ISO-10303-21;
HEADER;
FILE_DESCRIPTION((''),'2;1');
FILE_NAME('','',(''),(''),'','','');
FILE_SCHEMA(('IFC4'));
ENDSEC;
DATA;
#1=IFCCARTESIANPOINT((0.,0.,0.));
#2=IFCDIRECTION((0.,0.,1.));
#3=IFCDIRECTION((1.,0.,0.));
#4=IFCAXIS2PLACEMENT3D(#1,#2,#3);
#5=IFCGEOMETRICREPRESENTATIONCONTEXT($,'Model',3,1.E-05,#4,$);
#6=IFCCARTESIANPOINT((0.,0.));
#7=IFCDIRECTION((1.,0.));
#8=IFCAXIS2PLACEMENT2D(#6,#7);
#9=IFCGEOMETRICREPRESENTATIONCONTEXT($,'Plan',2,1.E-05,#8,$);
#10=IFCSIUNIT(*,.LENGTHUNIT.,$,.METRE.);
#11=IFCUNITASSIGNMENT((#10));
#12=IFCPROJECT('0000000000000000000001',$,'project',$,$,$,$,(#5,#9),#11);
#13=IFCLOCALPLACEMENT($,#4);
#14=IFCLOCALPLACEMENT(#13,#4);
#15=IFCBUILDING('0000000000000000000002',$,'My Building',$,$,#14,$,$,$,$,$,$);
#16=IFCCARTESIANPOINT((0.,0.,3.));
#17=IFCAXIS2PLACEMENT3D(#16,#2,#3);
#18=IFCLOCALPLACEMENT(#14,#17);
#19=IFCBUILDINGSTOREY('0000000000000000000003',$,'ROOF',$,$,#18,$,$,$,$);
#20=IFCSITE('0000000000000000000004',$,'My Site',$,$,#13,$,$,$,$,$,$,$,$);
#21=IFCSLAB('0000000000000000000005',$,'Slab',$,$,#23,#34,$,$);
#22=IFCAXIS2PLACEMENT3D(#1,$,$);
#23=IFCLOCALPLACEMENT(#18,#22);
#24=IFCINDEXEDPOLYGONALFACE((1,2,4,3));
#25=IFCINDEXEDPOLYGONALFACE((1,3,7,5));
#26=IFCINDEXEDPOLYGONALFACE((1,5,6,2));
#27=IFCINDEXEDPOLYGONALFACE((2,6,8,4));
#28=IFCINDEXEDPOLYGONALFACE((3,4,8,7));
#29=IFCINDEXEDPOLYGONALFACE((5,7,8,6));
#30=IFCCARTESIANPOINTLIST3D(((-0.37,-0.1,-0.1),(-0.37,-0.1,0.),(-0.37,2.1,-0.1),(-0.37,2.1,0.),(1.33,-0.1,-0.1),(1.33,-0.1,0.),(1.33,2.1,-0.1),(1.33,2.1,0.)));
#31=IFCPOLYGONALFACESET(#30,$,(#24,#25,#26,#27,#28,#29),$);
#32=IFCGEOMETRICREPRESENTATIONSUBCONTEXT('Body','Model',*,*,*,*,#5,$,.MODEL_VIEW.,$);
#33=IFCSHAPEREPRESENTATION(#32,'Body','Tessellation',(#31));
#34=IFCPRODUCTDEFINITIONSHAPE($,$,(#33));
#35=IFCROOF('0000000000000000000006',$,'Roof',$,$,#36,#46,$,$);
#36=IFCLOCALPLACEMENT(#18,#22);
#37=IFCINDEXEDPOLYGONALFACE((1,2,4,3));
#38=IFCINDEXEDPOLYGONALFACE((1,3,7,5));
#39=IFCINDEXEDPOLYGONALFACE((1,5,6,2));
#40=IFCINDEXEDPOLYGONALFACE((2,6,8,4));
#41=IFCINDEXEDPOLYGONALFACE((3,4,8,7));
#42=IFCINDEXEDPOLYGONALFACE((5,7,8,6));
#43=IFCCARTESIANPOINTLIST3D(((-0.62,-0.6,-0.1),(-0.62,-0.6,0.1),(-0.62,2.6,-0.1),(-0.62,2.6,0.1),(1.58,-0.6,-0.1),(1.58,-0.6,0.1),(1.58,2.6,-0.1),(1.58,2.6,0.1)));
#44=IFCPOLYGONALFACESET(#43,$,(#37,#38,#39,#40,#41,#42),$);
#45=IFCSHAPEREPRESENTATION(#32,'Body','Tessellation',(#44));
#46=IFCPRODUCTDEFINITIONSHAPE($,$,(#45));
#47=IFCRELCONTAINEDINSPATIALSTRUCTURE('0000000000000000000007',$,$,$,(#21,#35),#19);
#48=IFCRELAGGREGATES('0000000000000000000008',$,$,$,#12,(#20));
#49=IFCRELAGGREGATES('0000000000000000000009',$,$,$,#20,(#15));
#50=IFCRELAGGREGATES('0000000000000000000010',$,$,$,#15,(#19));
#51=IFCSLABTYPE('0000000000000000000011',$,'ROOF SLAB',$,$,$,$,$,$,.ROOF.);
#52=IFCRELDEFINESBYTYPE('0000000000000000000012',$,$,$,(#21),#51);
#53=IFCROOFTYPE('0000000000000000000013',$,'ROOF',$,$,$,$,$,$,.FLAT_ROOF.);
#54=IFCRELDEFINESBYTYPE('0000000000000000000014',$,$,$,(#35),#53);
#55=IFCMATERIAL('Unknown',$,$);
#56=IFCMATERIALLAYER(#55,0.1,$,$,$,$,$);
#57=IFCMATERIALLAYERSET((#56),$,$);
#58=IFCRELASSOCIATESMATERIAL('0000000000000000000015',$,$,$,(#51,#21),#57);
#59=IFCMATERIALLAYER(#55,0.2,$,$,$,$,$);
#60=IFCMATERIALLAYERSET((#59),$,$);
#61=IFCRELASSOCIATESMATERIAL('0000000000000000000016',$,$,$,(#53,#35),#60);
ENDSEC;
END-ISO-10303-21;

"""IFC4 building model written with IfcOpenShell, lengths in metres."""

from ifc_helpers import new_model, si_unit, frame, origin_with_axes, origin_2d_with_axis, place, context, subcontext, project, spatial, indexed_curve, outline, extrude, material, layer, layer_set, layer_usage, type_object, element, save


model = new_model("IFC4")

# Units and contexts
model_context = context("Model", 3, precision=1e-05, world=origin_with_axes())
plan_context = context("Plan", 2, precision=1e-05, world=origin_2d_with_axis())
body_context = subcontext(model_context, "Body", "Model", "MODEL_VIEW")
ifc_project = project(units=[si_unit("LENGTHUNIT", "METRE")], contexts=[model_context, plan_context])

# Site, building, storey
site_placement = place(None, origin_with_axes())
site = spatial("IfcSite", under=ifc_project, at=site_placement, Name="My Site")
building_placement = place(site_placement, origin_with_axes())
building = spatial("IfcBuilding", under=site, at=building_placement, Name="My Building")
storey_placement = place(building_placement, frame((0.0, 0.0, 3.0), z_axis=(0.0, 0.0, 1.0), x_axis=(1.0, 0.0, 0.0)))
storey = spatial("IfcBuildingStorey", under=building, at=storey_placement, Name="ROOF")

# Slab
ifc_material = material(Name="Unknown")
ifc_layer_1 = layer(ifc_material, 0.1)
ifc_layer_set_1 = layer_set([ifc_layer_1])
ifc_layer_usage_1 = layer_usage(ifc_layer_set_1, "AXIS3", "POSITIVE", -0.1)
slab_type = type_object("IfcSlabType", Name="ROOF SLAB", PredefinedType="ROOF", material=ifc_layer_set_1)
slab_placement = place(storey_placement, frame((-0.37, 2.1, 0.0), z_axis=(0.0, 0.0, 1.0), x_axis=(1.0, 0.0, 0.0)))
element("IfcSlab", 1, at=slab_placement, inside=storey, type_object=slab_type, material=ifc_layer_usage_1, Name="Slab", context=body_context, shape_type="SweptSolid", body=[
    extrude(outline(indexed_curve([(0.0, 0.0), (1.7, 0.0), (1.7, -2.2), (0.0, -2.2), (0.0, 0.0)])), frame((0.0, 0.0, -0.1), z_axis=(0.0, 0.0, 1.0), x_axis=(1.0, 0.0, 0.0)), (0.0, 0.0, 1.0), 0.1),
])

# Roof
ifc_layer_2 = layer(ifc_material, 0.2)
ifc_layer_set_2 = layer_set([ifc_layer_2])
ifc_layer_usage_2 = layer_usage(ifc_layer_set_2, "AXIS3", "POSITIVE", -0.1)
roof_type = type_object("IfcRoofType", Name="ROOF", PredefinedType="FLAT_ROOF", material=ifc_layer_set_2)
roof_placement = place(storey_placement, frame((-0.62, 2.6, 0.0), z_axis=(0.0, 0.0, 1.0), x_axis=(1.0, 0.0, 0.0)))
element("IfcRoof", 2, at=roof_placement, inside=storey, type_object=roof_type, material=ifc_layer_usage_2, Name="Roof", context=body_context, shape_type="SweptSolid", body=[
    extrude(outline(indexed_curve([(0.0, 0.0), (2.2, 0.0), (2.2, -3.2), (0.0, -3.2), (0.0, 0.0)])), frame((0.0, 0.0, -0.1), z_axis=(0.0, 0.0, 1.0), x_axis=(1.0, 0.0, 0.0)), (0.0, 0.0, 1.0), 0.2),
])

save(model, "model.ifc")
